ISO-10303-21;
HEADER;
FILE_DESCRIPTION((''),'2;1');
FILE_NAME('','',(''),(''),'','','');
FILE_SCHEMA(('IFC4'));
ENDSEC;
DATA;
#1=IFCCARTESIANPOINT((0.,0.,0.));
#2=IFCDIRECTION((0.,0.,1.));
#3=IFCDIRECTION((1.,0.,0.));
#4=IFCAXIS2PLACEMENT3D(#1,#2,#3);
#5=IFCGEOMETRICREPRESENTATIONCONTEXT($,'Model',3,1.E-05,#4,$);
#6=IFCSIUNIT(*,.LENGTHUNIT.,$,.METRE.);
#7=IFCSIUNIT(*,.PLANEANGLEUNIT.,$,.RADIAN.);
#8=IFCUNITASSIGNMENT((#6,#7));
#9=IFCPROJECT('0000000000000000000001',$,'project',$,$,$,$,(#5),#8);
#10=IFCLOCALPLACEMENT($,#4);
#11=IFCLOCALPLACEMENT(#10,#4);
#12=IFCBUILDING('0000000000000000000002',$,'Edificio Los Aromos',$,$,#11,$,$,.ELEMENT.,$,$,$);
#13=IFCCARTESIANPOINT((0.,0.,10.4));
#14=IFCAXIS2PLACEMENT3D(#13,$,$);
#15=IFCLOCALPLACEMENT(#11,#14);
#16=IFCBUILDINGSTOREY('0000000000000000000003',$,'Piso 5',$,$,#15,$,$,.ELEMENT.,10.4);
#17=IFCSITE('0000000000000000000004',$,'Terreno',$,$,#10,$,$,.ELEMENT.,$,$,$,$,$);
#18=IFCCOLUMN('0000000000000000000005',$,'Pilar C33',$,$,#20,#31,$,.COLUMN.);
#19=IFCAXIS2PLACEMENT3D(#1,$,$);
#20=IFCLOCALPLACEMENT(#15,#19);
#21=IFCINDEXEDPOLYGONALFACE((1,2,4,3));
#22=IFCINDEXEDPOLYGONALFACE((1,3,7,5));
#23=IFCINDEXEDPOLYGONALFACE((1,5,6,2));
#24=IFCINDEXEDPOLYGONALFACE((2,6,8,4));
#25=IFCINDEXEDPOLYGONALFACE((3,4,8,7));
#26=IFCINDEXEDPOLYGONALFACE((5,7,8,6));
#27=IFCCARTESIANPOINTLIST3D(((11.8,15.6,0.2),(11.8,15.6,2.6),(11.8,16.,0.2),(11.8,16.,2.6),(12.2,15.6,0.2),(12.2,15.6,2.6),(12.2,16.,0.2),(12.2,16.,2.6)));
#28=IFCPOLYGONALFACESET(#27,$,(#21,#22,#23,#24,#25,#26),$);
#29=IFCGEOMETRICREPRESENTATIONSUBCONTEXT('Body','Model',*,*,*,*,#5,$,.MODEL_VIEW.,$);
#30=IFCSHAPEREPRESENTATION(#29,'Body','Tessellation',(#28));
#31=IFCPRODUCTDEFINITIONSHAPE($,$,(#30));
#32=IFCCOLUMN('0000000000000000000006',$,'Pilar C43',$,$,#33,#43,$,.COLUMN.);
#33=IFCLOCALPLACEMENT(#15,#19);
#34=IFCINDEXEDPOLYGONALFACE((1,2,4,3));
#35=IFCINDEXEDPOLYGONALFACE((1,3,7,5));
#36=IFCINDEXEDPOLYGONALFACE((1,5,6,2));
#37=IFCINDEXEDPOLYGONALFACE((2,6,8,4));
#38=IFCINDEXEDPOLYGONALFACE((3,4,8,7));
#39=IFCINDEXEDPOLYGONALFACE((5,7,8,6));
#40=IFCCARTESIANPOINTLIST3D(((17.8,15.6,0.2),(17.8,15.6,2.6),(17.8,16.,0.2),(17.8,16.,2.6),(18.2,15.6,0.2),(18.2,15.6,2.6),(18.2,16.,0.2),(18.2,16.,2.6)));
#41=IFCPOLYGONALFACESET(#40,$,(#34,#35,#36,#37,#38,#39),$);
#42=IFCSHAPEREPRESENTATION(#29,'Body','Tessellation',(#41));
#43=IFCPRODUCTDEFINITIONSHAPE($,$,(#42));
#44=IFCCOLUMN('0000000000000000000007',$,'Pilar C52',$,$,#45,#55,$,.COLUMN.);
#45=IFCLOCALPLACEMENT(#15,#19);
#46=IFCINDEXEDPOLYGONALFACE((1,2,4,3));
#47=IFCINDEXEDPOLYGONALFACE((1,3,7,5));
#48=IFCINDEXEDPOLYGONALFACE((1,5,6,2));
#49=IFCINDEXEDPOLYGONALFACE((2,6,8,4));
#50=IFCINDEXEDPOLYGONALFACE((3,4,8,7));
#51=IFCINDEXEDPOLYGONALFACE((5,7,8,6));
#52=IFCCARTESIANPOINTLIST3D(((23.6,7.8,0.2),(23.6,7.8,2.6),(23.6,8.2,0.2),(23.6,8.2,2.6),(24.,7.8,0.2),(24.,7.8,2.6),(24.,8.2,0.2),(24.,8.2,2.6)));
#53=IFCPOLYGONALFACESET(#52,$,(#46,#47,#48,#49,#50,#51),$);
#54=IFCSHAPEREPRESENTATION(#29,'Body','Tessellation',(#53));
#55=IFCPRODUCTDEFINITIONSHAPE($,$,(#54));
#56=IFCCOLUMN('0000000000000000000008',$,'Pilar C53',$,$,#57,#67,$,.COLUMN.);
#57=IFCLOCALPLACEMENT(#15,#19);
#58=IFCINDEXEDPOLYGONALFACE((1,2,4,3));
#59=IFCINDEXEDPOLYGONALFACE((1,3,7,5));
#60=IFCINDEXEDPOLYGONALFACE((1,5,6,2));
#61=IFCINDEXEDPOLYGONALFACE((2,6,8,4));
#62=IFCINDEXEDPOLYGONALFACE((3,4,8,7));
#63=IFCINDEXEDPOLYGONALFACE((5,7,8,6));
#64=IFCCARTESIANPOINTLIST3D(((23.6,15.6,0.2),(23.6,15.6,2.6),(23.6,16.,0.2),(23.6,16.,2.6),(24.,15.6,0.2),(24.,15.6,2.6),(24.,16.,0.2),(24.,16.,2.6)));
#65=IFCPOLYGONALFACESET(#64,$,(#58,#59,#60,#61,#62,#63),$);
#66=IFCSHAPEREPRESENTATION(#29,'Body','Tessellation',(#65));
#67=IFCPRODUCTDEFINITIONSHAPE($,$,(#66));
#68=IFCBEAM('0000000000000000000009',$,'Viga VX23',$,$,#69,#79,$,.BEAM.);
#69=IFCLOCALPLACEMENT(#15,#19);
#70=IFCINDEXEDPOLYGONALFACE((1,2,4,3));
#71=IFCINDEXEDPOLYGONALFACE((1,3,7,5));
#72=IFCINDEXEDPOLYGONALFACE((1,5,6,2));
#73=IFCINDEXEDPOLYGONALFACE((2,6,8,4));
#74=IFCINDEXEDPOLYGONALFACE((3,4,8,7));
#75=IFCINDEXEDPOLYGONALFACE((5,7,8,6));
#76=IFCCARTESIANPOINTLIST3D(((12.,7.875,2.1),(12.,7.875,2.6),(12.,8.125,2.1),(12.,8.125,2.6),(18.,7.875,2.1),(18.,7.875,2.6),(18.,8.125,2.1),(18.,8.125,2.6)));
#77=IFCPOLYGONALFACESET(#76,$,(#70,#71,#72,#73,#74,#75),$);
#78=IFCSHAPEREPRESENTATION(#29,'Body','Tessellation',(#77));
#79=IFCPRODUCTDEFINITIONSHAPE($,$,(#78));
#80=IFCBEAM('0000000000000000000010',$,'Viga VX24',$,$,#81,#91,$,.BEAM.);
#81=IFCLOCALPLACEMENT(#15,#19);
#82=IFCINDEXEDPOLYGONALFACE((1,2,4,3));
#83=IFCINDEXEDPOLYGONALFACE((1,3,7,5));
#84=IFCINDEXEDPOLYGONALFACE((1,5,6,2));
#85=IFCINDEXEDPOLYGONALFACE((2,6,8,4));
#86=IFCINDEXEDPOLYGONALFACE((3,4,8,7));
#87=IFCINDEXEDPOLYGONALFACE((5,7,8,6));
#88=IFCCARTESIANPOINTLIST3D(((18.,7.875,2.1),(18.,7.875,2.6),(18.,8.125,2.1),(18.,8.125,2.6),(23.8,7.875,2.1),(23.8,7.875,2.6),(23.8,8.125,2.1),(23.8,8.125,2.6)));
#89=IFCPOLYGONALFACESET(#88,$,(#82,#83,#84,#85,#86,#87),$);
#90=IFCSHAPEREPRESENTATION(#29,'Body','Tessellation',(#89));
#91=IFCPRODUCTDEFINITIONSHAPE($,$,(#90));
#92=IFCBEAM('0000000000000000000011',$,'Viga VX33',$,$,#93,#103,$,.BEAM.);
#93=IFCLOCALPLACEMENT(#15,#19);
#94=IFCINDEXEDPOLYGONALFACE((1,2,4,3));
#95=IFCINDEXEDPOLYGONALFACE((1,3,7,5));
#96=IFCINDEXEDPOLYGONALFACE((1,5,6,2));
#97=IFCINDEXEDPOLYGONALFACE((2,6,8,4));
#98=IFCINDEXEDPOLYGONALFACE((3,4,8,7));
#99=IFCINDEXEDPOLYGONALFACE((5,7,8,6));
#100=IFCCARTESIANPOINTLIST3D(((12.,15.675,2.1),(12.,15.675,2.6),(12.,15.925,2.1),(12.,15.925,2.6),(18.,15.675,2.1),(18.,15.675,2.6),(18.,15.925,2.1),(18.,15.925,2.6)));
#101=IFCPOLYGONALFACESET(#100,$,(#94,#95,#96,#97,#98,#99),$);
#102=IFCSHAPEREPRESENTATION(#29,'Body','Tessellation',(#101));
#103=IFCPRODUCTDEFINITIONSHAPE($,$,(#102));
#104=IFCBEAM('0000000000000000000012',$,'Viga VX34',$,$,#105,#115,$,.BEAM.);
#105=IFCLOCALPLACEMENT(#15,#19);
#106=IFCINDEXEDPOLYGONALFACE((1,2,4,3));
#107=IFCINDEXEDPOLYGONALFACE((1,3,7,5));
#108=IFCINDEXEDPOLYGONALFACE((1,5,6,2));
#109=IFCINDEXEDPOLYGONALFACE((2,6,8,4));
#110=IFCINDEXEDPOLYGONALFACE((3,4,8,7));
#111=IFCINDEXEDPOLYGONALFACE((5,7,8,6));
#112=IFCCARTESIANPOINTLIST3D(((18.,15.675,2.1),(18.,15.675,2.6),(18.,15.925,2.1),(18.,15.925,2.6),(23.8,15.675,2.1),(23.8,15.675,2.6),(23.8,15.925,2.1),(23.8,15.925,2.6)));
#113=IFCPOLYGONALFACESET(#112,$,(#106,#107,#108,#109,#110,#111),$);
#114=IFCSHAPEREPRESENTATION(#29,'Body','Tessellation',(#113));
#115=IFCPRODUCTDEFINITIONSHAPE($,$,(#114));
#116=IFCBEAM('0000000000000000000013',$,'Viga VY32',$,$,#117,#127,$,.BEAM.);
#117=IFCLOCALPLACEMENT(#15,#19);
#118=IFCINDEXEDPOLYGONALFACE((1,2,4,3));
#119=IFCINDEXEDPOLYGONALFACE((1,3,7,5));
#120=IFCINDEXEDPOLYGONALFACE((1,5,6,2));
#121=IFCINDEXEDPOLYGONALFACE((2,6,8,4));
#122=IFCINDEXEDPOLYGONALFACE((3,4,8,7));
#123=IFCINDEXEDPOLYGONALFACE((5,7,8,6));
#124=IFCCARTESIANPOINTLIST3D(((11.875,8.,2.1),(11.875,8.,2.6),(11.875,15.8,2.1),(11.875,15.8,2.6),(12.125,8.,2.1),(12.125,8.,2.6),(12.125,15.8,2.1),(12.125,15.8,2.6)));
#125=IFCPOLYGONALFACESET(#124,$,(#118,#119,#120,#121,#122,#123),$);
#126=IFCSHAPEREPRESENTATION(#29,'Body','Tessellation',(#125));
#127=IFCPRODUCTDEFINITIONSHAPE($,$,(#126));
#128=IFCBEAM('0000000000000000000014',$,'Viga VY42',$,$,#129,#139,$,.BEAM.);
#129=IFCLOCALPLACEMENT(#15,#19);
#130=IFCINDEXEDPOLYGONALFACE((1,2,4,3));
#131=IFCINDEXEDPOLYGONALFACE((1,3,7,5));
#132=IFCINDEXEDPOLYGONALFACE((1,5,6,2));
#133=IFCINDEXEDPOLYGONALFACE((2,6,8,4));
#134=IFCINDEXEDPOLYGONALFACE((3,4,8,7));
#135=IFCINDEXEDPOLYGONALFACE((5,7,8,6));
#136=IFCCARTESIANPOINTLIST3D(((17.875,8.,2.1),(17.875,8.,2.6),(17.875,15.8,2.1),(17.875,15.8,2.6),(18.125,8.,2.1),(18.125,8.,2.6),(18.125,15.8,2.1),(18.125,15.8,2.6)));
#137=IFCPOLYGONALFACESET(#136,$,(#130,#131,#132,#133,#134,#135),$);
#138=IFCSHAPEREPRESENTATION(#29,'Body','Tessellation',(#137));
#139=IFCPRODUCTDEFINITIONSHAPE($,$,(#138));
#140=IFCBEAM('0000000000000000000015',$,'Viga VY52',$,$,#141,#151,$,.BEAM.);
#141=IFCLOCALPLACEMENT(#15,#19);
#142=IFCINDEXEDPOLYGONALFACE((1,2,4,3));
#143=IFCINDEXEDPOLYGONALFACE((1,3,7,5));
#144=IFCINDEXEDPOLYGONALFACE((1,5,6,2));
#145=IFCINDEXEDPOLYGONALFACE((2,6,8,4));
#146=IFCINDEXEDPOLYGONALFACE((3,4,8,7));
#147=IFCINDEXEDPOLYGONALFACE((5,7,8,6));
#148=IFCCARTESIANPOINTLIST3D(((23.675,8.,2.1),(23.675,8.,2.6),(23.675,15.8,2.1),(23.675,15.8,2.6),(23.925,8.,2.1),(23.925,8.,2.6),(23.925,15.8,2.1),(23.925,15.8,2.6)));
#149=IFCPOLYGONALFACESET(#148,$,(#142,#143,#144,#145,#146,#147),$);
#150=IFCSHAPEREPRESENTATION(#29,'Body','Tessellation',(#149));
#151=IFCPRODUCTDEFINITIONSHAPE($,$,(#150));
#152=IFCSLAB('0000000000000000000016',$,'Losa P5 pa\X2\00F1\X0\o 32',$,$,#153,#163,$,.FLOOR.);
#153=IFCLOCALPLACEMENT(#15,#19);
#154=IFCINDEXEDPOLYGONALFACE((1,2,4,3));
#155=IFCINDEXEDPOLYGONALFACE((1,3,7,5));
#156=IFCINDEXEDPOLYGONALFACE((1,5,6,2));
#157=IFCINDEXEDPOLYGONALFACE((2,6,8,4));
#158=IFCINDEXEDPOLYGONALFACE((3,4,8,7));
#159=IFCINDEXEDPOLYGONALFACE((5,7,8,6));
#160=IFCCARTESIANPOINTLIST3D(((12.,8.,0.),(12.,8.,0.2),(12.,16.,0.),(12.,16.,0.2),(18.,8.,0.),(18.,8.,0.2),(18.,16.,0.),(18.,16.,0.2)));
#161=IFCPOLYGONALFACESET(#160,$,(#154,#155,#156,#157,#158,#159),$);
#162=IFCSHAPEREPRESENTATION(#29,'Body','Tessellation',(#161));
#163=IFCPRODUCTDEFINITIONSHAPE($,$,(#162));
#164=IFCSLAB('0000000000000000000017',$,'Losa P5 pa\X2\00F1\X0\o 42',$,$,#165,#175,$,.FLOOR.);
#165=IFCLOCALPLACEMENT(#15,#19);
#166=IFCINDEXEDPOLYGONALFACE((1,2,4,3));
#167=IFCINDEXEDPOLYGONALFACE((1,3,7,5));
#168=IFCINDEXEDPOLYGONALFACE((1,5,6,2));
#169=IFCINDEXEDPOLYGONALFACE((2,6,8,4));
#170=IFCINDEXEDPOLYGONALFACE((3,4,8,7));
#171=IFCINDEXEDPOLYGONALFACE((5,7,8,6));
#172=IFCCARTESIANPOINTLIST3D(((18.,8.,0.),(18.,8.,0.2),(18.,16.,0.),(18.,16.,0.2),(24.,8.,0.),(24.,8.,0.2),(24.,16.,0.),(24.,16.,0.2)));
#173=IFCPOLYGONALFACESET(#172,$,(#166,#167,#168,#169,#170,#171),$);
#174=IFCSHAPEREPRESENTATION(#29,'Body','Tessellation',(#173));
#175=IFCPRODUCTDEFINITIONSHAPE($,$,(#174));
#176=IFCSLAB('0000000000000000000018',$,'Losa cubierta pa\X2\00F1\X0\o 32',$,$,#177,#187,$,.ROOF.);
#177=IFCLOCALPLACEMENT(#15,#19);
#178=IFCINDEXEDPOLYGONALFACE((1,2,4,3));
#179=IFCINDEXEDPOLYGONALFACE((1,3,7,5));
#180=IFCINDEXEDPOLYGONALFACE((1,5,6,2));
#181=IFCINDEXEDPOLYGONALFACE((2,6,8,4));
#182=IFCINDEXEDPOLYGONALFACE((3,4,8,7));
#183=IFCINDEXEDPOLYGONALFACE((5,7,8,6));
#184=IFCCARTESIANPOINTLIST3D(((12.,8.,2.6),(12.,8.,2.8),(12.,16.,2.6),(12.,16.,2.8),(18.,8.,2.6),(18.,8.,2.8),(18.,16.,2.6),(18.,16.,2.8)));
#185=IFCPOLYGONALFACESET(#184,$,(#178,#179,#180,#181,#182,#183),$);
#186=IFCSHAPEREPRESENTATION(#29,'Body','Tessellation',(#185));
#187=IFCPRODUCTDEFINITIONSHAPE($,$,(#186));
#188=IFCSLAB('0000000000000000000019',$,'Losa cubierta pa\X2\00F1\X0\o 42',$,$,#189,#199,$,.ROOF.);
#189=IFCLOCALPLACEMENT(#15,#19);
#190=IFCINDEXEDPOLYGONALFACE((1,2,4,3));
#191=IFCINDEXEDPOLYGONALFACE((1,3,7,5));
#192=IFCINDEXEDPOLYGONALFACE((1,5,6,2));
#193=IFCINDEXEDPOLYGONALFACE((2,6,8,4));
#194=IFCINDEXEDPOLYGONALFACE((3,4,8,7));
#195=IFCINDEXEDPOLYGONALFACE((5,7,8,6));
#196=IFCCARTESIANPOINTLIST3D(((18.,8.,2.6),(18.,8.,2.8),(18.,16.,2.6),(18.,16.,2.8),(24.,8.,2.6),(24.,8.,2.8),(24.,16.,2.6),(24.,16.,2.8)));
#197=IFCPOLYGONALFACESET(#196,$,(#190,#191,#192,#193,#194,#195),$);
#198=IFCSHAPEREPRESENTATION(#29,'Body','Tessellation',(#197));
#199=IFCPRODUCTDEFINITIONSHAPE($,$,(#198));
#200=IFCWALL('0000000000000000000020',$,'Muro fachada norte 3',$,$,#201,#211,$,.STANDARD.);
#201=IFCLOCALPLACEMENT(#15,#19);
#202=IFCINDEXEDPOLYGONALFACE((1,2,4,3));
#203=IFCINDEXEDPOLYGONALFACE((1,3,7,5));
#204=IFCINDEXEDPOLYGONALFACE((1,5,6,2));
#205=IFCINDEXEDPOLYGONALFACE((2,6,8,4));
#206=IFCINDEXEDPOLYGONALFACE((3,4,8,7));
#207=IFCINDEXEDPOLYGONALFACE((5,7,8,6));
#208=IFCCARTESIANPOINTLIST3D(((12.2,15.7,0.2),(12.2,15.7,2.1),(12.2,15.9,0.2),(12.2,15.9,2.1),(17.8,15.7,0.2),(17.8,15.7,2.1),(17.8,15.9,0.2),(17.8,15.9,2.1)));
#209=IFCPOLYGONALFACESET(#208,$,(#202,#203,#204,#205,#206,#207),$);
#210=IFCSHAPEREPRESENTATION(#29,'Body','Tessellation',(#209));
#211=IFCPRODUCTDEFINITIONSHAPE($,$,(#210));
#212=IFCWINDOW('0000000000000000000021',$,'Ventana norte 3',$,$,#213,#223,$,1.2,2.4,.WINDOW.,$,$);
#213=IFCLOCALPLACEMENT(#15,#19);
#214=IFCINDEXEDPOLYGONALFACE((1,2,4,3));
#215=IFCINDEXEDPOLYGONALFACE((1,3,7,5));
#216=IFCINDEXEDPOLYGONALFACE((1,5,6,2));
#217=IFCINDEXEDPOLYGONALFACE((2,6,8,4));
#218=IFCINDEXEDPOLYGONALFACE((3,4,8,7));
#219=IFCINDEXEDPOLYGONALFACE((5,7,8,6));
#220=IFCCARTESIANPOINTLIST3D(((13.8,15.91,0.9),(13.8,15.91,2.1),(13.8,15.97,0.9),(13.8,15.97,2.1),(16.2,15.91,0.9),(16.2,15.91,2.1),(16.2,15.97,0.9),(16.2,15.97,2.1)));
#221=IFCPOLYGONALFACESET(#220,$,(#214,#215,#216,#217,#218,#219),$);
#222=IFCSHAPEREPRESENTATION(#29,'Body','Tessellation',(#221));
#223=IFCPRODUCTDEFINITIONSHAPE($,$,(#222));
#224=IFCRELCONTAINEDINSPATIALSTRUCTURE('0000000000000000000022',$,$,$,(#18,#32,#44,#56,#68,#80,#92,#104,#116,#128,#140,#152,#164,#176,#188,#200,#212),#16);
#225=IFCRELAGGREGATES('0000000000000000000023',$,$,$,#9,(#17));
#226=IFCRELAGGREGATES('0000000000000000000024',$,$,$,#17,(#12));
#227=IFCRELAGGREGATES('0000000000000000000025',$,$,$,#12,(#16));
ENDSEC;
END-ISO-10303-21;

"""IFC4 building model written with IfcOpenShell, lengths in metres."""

from ifc_helpers import new_model, si_unit, frame, frame_2d, origin_with_axes, place, context, subcontext, project, spatial, rectangle, extrude, element, save


model = new_model("IFC4")

# Units and contexts
model_context = context("Model", 3, precision=1e-05, world=origin_with_axes())
body_context = subcontext(model_context, "Body", "Model", "MODEL_VIEW")
ifc_project = project(units=[si_unit("LENGTHUNIT", "METRE"), si_unit("PLANEANGLEUNIT", "RADIAN")], contexts=[model_context])

# Site, building, storey
site_placement = place(None, origin_with_axes())
site = spatial("IfcSite", under=ifc_project, at=site_placement, Name="Terreno", CompositionType="ELEMENT")
building_placement = place(site_placement, origin_with_axes())
building = spatial("IfcBuilding", under=site, at=building_placement, Name="Edificio Los Aromos", CompositionType="ELEMENT")
storey_placement = place(building_placement, frame((0.0, 0.0, 10.4)))
storey = spatial("IfcBuildingStorey", under=building, at=storey_placement, Name="Piso 5", CompositionType="ELEMENT", Elevation=10.4)

# Columns
for number, where, name in (
    (1, (11.8, 15.6, 0.2), "Pilar C33"),
    (2, (17.8, 15.6, 0.2), "Pilar C43"),
    (3, (23.6, 7.8, 0.2), "Pilar C52"),
    (4, (23.6, 15.6, 0.2), "Pilar C53"),
):
    element("IfcColumn", number, at=place(storey_placement, frame(where)), inside=storey, Name=name, PredefinedType="COLUMN", context=body_context, shape_type="SweptSolid", body=[
        extrude(rectangle(XDim=0.4, YDim=0.4, at=frame_2d((0.2, 0.2))), origin_with_axes(), (0.0, 0.0, 1.0), 2.4),
    ])

# Beams
beam_1_placement = place(storey_placement, frame((12.0, 7.875, 2.1)))
element("IfcBeam", 5, at=beam_1_placement, inside=storey, Name="Viga VX23", PredefinedType="BEAM", context=body_context, shape_type="SweptSolid", body=[
    extrude(rectangle(XDim=6.0, YDim=0.25, at=frame_2d((3.0, 0.125))), origin_with_axes(), (0.0, 0.0, 1.0), 0.5),
])
beam_2_placement = place(storey_placement, frame((18.0, 7.875, 2.1)))
element("IfcBeam", 6, at=beam_2_placement, inside=storey, Name="Viga VX24", PredefinedType="BEAM", context=body_context, shape_type="SweptSolid", body=[
    extrude(rectangle(XDim=5.8, YDim=0.25, at=frame_2d((2.9, 0.125))), origin_with_axes(), (0.0, 0.0, 1.0), 0.5),
])
beam_3_placement = place(storey_placement, frame((12.0, 15.675, 2.1)))
element("IfcBeam", 7, at=beam_3_placement, inside=storey, Name="Viga VX33", PredefinedType="BEAM", context=body_context, shape_type="SweptSolid", body=[
    extrude(rectangle(XDim=6.0, YDim=0.25, at=frame_2d((3.0, 0.125))), origin_with_axes(), (0.0, 0.0, 1.0), 0.5),
])
beam_4_placement = place(storey_placement, frame((18.0, 15.675, 2.1)))
element("IfcBeam", 8, at=beam_4_placement, inside=storey, Name="Viga VX34", PredefinedType="BEAM", context=body_context, shape_type="SweptSolid", body=[
    extrude(rectangle(XDim=5.8, YDim=0.25, at=frame_2d((2.9, 0.125))), origin_with_axes(), (0.0, 0.0, 1.0), 0.5),
])
for number, where, name in (
    (9, (11.875, 8.0, 2.1), "Viga VY32"),
    (10, (17.875, 8.0, 2.1), "Viga VY42"),
    (11, (23.675, 8.0, 2.1), "Viga VY52"),
):
    element("IfcBeam", number, at=place(storey_placement, frame(where)), inside=storey, Name=name, PredefinedType="BEAM", context=body_context, shape_type="SweptSolid", body=[
        extrude(rectangle(XDim=0.25, YDim=7.8, at=frame_2d((0.125, 3.9))), origin_with_axes(), (0.0, 0.0, 1.0), 0.5),
    ])

# Slabs
for number, where, name in (
    (12, (12.0, 8.0, 0.0), "Losa P5 paño 32"),
    (13, (18.0, 8.0, 0.0), "Losa P5 paño 42"),
):
    element("IfcSlab", number, at=place(storey_placement, frame(where)), inside=storey, Name=name, PredefinedType="FLOOR", context=body_context, shape_type="SweptSolid", body=[
        extrude(rectangle(XDim=6.0, YDim=8.0, at=frame_2d((3.0, 4.0))), origin_with_axes(), (0.0, 0.0, 1.0), 0.2),
    ])
for number, where, name in (
    (14, (12.0, 8.0, 2.6), "Losa cubierta paño 32"),
    (15, (18.0, 8.0, 2.6), "Losa cubierta paño 42"),
):
    element("IfcSlab", number, at=place(storey_placement, frame(where)), inside=storey, Name=name, PredefinedType="ROOF", context=body_context, shape_type="SweptSolid", body=[
        extrude(rectangle(XDim=6.0, YDim=8.0, at=frame_2d((3.0, 4.0))), origin_with_axes(), (0.0, 0.0, 1.0), 0.2),
    ])

# Wall
wall_1_placement = place(storey_placement, frame((12.2, 15.7, 0.2)))
element("IfcWall", 16, at=wall_1_placement, inside=storey, Name="Muro fachada norte 3", PredefinedType="STANDARD", context=body_context, shape_type="SweptSolid", body=[
    extrude(rectangle(XDim=5.6, YDim=0.2, at=frame_2d((2.8, 0.1))), origin_with_axes(), (0.0, 0.0, 1.0), 1.9),
])

# Window
window_1_placement = place(storey_placement, frame((13.8, 15.91, 0.9)))
element("IfcWindow", 17, at=window_1_placement, inside=storey, Name="Ventana norte 3", OverallHeight=1.2, OverallWidth=2.4, PredefinedType="WINDOW", context=body_context, shape_type="SweptSolid", body=[
    extrude(rectangle(XDim=2.4, YDim=0.06, at=frame_2d((1.2, 0.03))), origin_with_axes(), (0.0, 0.0, 1.0), 1.2),
])

save(model, "model.ifc")
